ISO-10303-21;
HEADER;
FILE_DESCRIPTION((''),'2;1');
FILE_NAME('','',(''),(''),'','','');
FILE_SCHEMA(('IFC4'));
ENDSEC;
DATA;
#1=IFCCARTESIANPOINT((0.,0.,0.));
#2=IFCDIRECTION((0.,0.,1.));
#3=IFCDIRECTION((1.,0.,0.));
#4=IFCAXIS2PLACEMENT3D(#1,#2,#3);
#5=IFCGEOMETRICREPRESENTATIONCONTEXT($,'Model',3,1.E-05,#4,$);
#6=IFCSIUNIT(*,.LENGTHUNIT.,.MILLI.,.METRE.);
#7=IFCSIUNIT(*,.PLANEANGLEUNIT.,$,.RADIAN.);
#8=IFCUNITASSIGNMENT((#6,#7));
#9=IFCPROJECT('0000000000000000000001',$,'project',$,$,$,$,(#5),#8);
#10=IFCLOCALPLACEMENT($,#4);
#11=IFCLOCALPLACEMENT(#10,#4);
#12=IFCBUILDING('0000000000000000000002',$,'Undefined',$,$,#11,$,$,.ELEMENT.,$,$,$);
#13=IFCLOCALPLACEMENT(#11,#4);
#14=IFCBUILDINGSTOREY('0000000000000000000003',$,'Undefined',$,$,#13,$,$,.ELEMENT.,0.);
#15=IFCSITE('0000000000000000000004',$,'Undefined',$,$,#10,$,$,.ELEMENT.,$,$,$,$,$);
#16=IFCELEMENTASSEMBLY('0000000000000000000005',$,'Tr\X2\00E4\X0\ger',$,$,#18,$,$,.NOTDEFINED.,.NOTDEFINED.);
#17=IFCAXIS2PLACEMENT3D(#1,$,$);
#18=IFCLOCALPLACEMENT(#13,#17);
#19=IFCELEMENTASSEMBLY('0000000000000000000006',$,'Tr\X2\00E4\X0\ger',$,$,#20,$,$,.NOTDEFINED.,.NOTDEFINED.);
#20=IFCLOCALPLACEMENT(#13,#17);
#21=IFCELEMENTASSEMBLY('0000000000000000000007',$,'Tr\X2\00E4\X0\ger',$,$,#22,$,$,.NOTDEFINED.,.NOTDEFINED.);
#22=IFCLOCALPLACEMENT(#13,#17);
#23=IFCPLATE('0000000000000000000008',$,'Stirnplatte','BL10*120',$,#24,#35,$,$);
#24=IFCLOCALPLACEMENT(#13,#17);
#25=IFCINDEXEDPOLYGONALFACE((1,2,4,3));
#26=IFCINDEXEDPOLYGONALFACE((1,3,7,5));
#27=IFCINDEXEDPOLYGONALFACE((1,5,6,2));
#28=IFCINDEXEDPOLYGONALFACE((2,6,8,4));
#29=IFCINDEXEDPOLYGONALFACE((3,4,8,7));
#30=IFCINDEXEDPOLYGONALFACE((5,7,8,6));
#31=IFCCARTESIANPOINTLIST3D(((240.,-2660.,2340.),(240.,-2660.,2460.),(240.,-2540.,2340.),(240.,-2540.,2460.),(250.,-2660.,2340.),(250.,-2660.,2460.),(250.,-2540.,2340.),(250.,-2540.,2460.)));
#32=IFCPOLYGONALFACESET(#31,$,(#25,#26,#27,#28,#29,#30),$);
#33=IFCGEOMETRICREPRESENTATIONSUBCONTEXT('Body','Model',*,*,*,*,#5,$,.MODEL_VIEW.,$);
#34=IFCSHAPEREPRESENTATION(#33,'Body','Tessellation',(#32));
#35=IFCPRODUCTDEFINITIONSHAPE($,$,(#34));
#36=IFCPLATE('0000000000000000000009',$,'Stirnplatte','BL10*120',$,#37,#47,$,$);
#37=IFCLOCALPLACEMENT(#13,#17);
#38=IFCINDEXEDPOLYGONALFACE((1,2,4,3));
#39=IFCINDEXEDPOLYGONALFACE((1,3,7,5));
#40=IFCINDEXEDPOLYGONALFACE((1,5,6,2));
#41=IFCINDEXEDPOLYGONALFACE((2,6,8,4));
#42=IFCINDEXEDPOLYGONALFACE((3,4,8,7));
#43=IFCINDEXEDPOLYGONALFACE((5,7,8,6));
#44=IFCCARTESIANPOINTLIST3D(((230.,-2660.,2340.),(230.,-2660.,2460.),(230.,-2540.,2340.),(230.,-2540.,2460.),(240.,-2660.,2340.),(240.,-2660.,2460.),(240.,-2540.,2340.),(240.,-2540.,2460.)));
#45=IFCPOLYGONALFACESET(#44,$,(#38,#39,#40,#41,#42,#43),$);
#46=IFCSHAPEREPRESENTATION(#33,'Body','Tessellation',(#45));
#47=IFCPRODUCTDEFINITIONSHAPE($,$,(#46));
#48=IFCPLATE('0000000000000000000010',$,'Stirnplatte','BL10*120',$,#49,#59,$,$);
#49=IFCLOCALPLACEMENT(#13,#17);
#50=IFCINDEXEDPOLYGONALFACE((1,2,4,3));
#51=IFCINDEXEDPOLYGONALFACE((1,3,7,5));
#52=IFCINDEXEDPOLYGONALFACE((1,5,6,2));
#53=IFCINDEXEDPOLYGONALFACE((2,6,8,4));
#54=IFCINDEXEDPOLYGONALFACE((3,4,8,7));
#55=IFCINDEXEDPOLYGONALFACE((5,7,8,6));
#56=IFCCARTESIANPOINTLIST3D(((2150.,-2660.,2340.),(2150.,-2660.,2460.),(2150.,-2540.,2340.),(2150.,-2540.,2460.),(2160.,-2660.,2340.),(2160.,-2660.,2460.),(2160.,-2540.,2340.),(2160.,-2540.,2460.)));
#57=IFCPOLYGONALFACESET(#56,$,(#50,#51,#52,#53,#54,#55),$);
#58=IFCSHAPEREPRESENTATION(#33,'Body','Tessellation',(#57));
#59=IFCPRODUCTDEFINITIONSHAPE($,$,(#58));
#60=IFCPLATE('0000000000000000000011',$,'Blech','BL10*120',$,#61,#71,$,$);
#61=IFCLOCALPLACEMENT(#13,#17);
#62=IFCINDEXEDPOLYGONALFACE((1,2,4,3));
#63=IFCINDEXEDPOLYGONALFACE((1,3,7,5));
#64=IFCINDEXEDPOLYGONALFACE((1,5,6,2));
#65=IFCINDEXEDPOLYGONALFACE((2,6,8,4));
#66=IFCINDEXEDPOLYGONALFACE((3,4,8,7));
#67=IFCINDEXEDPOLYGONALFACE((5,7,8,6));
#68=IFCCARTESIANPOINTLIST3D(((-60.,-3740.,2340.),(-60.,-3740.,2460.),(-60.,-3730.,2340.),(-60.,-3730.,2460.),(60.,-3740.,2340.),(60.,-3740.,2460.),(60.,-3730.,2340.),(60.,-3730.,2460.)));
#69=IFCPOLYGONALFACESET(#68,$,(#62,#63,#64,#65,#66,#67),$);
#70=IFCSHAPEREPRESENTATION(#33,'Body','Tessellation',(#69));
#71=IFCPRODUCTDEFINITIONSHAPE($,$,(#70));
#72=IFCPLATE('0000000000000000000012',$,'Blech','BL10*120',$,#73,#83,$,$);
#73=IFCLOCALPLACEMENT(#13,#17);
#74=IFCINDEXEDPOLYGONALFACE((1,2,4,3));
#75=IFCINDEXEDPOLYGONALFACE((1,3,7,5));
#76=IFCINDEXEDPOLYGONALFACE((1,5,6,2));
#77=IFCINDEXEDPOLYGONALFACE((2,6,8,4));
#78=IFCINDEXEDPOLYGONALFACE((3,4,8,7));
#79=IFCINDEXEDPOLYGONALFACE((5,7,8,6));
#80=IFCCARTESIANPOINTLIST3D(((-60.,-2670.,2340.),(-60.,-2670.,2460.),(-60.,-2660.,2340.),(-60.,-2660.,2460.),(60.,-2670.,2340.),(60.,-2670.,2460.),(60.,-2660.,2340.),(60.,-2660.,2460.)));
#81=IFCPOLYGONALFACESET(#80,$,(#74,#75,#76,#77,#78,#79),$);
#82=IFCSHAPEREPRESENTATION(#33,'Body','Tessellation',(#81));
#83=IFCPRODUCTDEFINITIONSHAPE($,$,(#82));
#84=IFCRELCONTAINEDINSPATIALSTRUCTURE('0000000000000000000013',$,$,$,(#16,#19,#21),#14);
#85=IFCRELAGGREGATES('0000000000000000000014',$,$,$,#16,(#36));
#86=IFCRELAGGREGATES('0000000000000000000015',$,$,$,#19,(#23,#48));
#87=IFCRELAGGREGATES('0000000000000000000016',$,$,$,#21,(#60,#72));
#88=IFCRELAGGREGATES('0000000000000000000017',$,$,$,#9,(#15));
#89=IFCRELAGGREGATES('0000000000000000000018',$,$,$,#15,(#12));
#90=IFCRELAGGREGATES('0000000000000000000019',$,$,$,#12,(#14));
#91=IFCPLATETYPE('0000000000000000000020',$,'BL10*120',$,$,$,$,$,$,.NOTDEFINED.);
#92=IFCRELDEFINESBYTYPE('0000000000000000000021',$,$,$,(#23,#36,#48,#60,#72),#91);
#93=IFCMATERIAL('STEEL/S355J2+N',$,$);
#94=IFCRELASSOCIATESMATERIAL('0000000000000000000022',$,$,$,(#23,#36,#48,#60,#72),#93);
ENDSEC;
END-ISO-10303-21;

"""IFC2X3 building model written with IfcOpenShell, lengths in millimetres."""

from ifc_helpers import new_model, si_unit, frame, origin_with_axes, place, context, subcontext, project, spatial, polyline, outline, extrude, material, type_object, element, aggregate, save


model = new_model("IFC2X3")

# Units and contexts
model_context = context("Model", 3, precision=1e-05, world=origin_with_axes())
body_context = subcontext(model_context, "Body", "Model", "MODEL_VIEW")
ifc_project = project(units=[si_unit("LENGTHUNIT", "METRE", prefix="MILLI"), si_unit("PLANEANGLEUNIT", "RADIAN")], contexts=[model_context])

# Site, building, storey
site_placement = place(None, origin_with_axes())
site = spatial("IfcSite", under=ifc_project, at=site_placement, Name="Undefined", CompositionType="ELEMENT")
building_placement = place(site_placement, origin_with_axes())
building = spatial("IfcBuilding", under=site, at=building_placement, Name="Undefined", CompositionType="ELEMENT")
storey_placement = place(building_placement, origin_with_axes())
storey = spatial("IfcBuildingStorey", under=building, at=storey_placement, Name="Undefined", CompositionType="ELEMENT", Elevation=0.0)

# Element assemblies
assembly_1_placement = place(storey_placement, origin_with_axes())
assembly_1 = element("IfcElementAssembly", 1, at=assembly_1_placement, inside=storey, Name="Träger", AssemblyPlace="NOTDEFINED", PredefinedType="NOTDEFINED")
assembly_2_placement = place(storey_placement, origin_with_axes())
assembly_2 = element("IfcElementAssembly", 2, at=assembly_2_placement, inside=storey, Name="Träger", AssemblyPlace="NOTDEFINED", PredefinedType="NOTDEFINED")
assembly_3_placement = place(storey_placement, origin_with_axes())
assembly_3 = element("IfcElementAssembly", 3, at=assembly_3_placement, inside=storey, Name="Träger", AssemblyPlace="NOTDEFINED", PredefinedType="NOTDEFINED")

# Plates
ifc_material_1 = material(Name="STEEL/S355J2+N")
plate_type = type_object("IfcPlateType", Name="BL10*120", PredefinedType="NOTDEFINED")
plate_1_placement = place(assembly_2_placement, frame((245.0, -2600.0, 2340.0), z_axis=(1.0, 0.0, 0.0), x_axis=(0.0, 0.0, 1.0)))
plate_1 = element("IfcPlate", 4, at=plate_1_placement, type_object=plate_type, material=ifc_material_1, Name="Stirnplatte", Description="BL10*120", context=body_context, shape_type="SweptSolid", body=[
    extrude(outline(polyline([(0.0, -60.0), (0.0, 60.0), (120.0, 60.0), (120.0, -60.0), (0.0, -60.0)])), frame((0.0, 0.0, -5.0), z_axis=(0.0, 0.0, 1.0), x_axis=(1.0, 0.0, 0.0)), (0.0, 0.0, 1.0), 10.0),
])
plate_2_placement = place(assembly_1_placement, frame((235.0, -2600.0, 2340.0), z_axis=(1.0, 0.0, 0.0), x_axis=(0.0, 0.0, 1.0)))
plate_2 = element("IfcPlate", 5, at=plate_2_placement, type_object=plate_type, material=ifc_material_1, Name="Stirnplatte", Description="BL10*120", context=body_context, shape_type="SweptSolid", body=[
    extrude(outline(polyline([(0.0, -60.0), (0.0, 60.0), (120.0, 60.0), (120.0, -60.0), (0.0, -60.0)])), frame((0.0, 0.0, -5.0), z_axis=(0.0, 0.0, 1.0), x_axis=(1.0, 0.0, 0.0)), (0.0, 0.0, 1.0), 10.0),
])
plate_3_placement = place(assembly_2_placement, frame((2155.0, -2600.0, 2340.0), z_axis=(-1.0, 0.0, 0.0), x_axis=(0.0, 0.0, 1.0)))
plate_3 = element("IfcPlate", 6, at=plate_3_placement, type_object=plate_type, material=ifc_material_1, Name="Stirnplatte", Description="BL10*120", context=body_context, shape_type="SweptSolid", body=[
    extrude(outline(polyline([(0.0, -60.0), (0.0, 60.0), (120.0, 60.0), (120.0, -60.0), (0.0, -60.0)])), frame((0.0, 0.0, -5.0), z_axis=(0.0, 0.0, 1.0), x_axis=(1.0, 0.0, 0.0)), (0.0, 0.0, 1.0), 10.0),
])
plate_4_placement = place(assembly_3_placement, frame((0.0, -3735.0, 2340.0), z_axis=(0.0, 1.0, 0.0), x_axis=(0.0, 0.0, 1.0)))
plate_4 = element("IfcPlate", 7, at=plate_4_placement, type_object=plate_type, material=ifc_material_1, Name="Blech", Description="BL10*120", context=body_context, shape_type="SweptSolid", body=[
    extrude(outline(polyline([(0.0, -60.0), (0.0, 60.0), (120.0, 60.0), (120.0, -60.0), (0.0, -60.0)])), frame((0.0, 0.0, -5.0), z_axis=(0.0, 0.0, 1.0), x_axis=(1.0, 0.0, 0.0)), (0.0, 0.0, 1.0), 10.0),
])
plate_5_placement = place(assembly_3_placement, frame((0.0, -2665.0, 2340.0), z_axis=(0.0, -1.0, 0.0), x_axis=(0.0, 0.0, 1.0)))
plate_5 = element("IfcPlate", 8, at=plate_5_placement, type_object=plate_type, material=ifc_material_1, Name="Blech", Description="BL10*120", context=body_context, shape_type="SweptSolid", body=[
    extrude(outline(polyline([(0.0, -60.0), (0.0, 60.0), (120.0, 60.0), (120.0, -60.0), (0.0, -60.0)])), frame((0.0, 0.0, -5.0), z_axis=(0.0, 0.0, 1.0), x_axis=(1.0, 0.0, 0.0)), (0.0, 0.0, 1.0), 10.0),
])

aggregate(assembly_1, [plate_2])
aggregate(assembly_2, [plate_1, plate_3])

aggregate(assembly_3, [plate_4, plate_5])

save(model, "model.ifc")
